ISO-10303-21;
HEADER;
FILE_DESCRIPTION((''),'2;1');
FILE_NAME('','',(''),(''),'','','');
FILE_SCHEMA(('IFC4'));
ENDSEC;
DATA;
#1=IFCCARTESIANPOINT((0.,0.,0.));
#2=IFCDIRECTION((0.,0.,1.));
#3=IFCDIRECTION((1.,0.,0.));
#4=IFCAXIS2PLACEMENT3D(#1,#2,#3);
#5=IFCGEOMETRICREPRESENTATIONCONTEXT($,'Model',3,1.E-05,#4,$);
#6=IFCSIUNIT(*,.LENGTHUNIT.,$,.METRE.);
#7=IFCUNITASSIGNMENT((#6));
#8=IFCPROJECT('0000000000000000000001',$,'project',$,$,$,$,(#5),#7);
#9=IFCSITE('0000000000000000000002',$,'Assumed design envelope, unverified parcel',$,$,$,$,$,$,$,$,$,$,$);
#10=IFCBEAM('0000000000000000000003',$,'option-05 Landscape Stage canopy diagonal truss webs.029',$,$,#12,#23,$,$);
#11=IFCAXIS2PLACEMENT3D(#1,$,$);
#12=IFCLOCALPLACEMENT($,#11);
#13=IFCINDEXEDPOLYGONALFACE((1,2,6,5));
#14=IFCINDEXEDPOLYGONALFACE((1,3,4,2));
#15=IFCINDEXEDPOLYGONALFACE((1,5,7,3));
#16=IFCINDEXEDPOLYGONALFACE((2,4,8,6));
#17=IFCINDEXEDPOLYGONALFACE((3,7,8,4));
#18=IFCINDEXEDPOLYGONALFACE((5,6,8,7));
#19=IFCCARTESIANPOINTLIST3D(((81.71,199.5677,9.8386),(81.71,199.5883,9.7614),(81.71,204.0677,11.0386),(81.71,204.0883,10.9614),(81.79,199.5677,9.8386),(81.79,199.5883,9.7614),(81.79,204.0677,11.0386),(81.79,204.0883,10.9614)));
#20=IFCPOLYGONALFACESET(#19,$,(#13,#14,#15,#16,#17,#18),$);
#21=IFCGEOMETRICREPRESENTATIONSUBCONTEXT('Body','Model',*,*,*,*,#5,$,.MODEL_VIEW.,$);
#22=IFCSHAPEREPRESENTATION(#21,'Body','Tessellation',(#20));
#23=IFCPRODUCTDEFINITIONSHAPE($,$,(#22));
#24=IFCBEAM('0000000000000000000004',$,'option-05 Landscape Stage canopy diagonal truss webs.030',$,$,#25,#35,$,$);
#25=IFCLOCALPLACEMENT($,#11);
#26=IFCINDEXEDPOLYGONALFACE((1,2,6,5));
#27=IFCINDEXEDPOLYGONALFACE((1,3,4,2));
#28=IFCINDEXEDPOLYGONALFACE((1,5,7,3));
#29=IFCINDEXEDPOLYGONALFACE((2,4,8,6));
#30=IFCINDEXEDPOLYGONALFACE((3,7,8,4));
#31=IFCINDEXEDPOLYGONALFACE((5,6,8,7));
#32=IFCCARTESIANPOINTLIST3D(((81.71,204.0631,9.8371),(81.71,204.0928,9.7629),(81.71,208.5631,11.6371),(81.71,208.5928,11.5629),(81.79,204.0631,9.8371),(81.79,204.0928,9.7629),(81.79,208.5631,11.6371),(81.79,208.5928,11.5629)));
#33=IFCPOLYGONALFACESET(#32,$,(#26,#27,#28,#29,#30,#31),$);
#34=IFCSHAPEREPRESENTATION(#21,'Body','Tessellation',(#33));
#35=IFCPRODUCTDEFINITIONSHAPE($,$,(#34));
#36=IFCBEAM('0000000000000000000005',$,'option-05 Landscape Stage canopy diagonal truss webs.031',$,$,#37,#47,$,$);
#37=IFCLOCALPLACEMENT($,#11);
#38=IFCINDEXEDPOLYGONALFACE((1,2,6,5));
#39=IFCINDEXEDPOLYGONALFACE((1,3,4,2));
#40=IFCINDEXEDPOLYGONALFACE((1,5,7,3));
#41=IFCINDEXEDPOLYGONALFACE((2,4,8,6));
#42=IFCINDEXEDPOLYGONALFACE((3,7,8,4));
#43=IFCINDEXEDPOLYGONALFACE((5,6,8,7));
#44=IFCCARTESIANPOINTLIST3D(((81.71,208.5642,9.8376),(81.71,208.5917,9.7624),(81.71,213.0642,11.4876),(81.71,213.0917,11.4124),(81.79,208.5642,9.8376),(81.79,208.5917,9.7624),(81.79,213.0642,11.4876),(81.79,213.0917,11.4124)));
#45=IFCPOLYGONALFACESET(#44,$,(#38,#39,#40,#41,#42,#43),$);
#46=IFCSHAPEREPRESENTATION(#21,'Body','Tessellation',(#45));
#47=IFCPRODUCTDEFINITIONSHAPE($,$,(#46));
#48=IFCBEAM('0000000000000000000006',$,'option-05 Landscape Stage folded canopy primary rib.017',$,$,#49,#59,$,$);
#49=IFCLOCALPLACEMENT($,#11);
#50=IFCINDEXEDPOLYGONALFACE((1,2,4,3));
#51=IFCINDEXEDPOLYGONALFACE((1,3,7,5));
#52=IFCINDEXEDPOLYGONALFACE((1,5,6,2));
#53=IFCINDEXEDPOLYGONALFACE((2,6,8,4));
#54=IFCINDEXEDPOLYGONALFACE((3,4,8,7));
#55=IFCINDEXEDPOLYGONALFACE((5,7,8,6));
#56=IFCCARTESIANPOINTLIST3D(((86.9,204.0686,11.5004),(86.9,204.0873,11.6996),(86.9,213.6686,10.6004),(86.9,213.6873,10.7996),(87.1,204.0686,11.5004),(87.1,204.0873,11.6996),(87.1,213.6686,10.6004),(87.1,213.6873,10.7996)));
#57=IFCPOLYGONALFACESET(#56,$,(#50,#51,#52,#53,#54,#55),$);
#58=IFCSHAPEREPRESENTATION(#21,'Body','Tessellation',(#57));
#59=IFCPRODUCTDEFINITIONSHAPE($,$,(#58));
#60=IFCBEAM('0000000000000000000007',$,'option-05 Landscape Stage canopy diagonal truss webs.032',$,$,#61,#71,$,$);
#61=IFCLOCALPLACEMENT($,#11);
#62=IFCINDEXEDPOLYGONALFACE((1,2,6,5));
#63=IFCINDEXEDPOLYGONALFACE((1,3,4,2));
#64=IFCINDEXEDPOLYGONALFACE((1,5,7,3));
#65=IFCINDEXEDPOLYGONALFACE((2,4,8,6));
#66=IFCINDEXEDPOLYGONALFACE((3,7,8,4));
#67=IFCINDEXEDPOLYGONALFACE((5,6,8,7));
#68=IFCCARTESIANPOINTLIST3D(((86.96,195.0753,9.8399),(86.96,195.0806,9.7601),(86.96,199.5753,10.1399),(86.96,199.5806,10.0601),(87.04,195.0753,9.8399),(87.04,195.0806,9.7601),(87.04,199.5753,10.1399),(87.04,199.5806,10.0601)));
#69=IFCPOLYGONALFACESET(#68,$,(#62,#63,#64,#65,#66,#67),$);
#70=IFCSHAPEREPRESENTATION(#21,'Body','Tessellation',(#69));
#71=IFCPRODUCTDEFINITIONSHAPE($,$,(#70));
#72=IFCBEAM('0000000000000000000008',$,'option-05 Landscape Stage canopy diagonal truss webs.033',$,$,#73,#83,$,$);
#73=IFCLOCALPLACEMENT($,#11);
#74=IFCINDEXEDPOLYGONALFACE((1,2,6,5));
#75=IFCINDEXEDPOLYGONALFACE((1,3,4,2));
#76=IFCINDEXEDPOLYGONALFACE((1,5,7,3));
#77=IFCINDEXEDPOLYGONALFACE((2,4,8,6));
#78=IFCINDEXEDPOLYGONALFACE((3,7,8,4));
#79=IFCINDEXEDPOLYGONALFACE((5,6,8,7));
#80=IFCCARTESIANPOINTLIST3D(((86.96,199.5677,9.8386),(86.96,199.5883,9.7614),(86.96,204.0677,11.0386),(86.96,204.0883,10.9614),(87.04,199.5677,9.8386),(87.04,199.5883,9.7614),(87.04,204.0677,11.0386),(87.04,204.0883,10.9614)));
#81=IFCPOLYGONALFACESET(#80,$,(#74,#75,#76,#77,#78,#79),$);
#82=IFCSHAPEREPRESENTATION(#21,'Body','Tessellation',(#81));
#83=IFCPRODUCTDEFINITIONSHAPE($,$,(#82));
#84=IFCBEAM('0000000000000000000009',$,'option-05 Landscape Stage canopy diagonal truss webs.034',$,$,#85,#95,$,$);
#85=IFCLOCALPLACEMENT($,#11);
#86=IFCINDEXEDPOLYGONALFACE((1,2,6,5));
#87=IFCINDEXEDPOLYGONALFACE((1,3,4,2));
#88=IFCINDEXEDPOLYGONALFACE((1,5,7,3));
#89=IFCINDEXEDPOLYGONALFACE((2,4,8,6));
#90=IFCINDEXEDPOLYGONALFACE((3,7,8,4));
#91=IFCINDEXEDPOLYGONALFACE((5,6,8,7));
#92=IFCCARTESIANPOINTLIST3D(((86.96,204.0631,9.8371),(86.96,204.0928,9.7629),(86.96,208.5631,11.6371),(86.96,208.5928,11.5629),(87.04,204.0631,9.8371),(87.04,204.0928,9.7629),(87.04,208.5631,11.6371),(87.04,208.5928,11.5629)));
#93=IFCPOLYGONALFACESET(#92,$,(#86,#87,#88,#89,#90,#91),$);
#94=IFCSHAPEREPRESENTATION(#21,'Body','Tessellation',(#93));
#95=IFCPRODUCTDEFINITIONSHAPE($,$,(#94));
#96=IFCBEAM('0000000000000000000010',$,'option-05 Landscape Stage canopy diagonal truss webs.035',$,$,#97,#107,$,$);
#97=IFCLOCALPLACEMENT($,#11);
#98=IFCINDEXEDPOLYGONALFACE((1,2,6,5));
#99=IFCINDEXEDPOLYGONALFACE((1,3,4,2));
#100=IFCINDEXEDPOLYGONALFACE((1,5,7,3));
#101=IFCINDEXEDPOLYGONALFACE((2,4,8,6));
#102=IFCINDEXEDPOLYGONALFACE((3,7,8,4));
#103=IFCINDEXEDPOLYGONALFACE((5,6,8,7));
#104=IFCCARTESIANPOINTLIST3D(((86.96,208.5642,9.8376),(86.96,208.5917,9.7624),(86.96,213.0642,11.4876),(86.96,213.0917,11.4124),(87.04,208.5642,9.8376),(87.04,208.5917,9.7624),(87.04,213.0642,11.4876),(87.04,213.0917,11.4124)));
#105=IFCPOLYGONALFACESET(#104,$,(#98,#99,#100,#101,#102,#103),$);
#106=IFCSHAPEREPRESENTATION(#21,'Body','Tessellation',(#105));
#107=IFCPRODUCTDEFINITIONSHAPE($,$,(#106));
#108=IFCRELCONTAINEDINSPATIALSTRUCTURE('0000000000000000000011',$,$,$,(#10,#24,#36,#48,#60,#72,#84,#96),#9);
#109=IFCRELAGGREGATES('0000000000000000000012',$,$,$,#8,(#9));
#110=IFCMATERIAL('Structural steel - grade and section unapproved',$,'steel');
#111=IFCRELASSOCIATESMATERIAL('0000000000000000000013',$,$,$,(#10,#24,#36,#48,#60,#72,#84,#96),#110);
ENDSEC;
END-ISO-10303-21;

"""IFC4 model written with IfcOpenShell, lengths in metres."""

from ifc_helpers import new_model, si_unit, frame, origin_with_axes, place, context, subcontext, project, spatial, rectangle, extrude, material, element, save


model = new_model("IFC4")

# Units and contexts
model_context = context("Model", 3, precision=1e-05, world=origin_with_axes())
body_context = subcontext(model_context, "Body", "Model", "MODEL_VIEW")
ifc_project = project(units=[si_unit("LENGTHUNIT", "METRE")], contexts=[model_context])

# Site
site = spatial("IfcSite", under=ifc_project, Name="Assumed design envelope, unverified parcel")

# Shared definitions
ifc_material = material(Name="Structural steel - grade and section unapproved", Category="steel")

# Beams
beam_1_placement = place(None, frame((81.75, 199.578, 9.8), z_axis=(0.0, 0.966235, 0.257663), x_axis=(-1.0, 0.0, 0.0)))
element("IfcBeam", 1, at=beam_1_placement, inside=site, material=ifc_material, Name="option-05 Landscape Stage canopy diagonal truss webs.029", context=body_context, shape_type="SweptSolid", body=[
    extrude(rectangle(XDim=0.08, YDim=0.08), origin_with_axes(), (0.0, 0.0, 1.0), 4.6573),
])
beam_2_placement = place(None, frame((81.75, 204.078, 9.8), z_axis=(0.0, 0.928477, 0.371391), x_axis=(-1.0, 0.0, 0.0)))
element("IfcBeam", 2, at=beam_2_placement, inside=site, material=ifc_material, Name="option-05 Landscape Stage canopy diagonal truss webs.030", context=body_context, shape_type="SweptSolid", body=[
    extrude(rectangle(XDim=0.08, YDim=0.08), origin_with_axes(), (0.0, 0.0, 1.0), 4.8466),
])
beam_3_placement = place(None, frame((81.75, 208.578, 9.8), z_axis=(0.0, 0.938876, 0.344255), x_axis=(-1.0, 0.0, 0.0)))
element("IfcBeam", 3, at=beam_3_placement, inside=site, material=ifc_material, Name="option-05 Landscape Stage canopy diagonal truss webs.031", context=body_context, shape_type="SweptSolid", body=[
    extrude(rectangle(XDim=0.08, YDim=0.08), origin_with_axes(), (0.0, 0.0, 1.0), 4.793),
])
beam_4_placement = place(None, frame((87.0, 204.078, 11.6), z_axis=(0.0, 0.995634, -0.093341), x_axis=(-1.0, 0.0, 0.0)))
element("IfcBeam", 4, at=beam_4_placement, inside=site, material=ifc_material, Name="option-05 Landscape Stage folded canopy primary rib.017", context=body_context, shape_type="SweptSolid", body=[
    extrude(rectangle(XDim=0.2, YDim=0.2), origin_with_axes(), (0.0, 0.0, 1.0), 9.6421),
])
beam_5_placement = place(None, frame((87.0, 195.078, 9.8), z_axis=(0.0, 0.997785, 0.066519), x_axis=(-1.0, 0.0, 0.0)))
element("IfcBeam", 5, at=beam_5_placement, inside=site, material=ifc_material, Name="option-05 Landscape Stage canopy diagonal truss webs.032", context=body_context, shape_type="SweptSolid", body=[
    extrude(rectangle(XDim=0.08, YDim=0.08), origin_with_axes(), (0.0, 0.0, 1.0), 4.51),
])
beam_6_placement = place(None, frame((87.0, 199.578, 9.8), z_axis=(0.0, 0.966235, 0.257663), x_axis=(-1.0, 0.0, 0.0)))
element("IfcBeam", 6, at=beam_6_placement, inside=site, material=ifc_material, Name="option-05 Landscape Stage canopy diagonal truss webs.033", context=body_context, shape_type="SweptSolid", body=[
    extrude(rectangle(XDim=0.08, YDim=0.08), origin_with_axes(), (0.0, 0.0, 1.0), 4.6573),
])
beam_7_placement = place(None, frame((87.0, 204.078, 9.8), z_axis=(0.0, 0.928477, 0.371391), x_axis=(-1.0, 0.0, 0.0)))
element("IfcBeam", 7, at=beam_7_placement, inside=site, material=ifc_material, Name="option-05 Landscape Stage canopy diagonal truss webs.034", context=body_context, shape_type="SweptSolid", body=[
    extrude(rectangle(XDim=0.08, YDim=0.08), origin_with_axes(), (0.0, 0.0, 1.0), 4.8466),
])
beam_8_placement = place(None, frame((87.0, 208.578, 9.8), z_axis=(0.0, 0.938876, 0.344255), x_axis=(-1.0, 0.0, 0.0)))
element("IfcBeam", 8, at=beam_8_placement, inside=site, material=ifc_material, Name="option-05 Landscape Stage canopy diagonal truss webs.035", context=body_context, shape_type="SweptSolid", body=[
    extrude(rectangle(XDim=0.08, YDim=0.08), origin_with_axes(), (0.0, 0.0, 1.0), 4.793),
])

save(model, "model.ifc")
